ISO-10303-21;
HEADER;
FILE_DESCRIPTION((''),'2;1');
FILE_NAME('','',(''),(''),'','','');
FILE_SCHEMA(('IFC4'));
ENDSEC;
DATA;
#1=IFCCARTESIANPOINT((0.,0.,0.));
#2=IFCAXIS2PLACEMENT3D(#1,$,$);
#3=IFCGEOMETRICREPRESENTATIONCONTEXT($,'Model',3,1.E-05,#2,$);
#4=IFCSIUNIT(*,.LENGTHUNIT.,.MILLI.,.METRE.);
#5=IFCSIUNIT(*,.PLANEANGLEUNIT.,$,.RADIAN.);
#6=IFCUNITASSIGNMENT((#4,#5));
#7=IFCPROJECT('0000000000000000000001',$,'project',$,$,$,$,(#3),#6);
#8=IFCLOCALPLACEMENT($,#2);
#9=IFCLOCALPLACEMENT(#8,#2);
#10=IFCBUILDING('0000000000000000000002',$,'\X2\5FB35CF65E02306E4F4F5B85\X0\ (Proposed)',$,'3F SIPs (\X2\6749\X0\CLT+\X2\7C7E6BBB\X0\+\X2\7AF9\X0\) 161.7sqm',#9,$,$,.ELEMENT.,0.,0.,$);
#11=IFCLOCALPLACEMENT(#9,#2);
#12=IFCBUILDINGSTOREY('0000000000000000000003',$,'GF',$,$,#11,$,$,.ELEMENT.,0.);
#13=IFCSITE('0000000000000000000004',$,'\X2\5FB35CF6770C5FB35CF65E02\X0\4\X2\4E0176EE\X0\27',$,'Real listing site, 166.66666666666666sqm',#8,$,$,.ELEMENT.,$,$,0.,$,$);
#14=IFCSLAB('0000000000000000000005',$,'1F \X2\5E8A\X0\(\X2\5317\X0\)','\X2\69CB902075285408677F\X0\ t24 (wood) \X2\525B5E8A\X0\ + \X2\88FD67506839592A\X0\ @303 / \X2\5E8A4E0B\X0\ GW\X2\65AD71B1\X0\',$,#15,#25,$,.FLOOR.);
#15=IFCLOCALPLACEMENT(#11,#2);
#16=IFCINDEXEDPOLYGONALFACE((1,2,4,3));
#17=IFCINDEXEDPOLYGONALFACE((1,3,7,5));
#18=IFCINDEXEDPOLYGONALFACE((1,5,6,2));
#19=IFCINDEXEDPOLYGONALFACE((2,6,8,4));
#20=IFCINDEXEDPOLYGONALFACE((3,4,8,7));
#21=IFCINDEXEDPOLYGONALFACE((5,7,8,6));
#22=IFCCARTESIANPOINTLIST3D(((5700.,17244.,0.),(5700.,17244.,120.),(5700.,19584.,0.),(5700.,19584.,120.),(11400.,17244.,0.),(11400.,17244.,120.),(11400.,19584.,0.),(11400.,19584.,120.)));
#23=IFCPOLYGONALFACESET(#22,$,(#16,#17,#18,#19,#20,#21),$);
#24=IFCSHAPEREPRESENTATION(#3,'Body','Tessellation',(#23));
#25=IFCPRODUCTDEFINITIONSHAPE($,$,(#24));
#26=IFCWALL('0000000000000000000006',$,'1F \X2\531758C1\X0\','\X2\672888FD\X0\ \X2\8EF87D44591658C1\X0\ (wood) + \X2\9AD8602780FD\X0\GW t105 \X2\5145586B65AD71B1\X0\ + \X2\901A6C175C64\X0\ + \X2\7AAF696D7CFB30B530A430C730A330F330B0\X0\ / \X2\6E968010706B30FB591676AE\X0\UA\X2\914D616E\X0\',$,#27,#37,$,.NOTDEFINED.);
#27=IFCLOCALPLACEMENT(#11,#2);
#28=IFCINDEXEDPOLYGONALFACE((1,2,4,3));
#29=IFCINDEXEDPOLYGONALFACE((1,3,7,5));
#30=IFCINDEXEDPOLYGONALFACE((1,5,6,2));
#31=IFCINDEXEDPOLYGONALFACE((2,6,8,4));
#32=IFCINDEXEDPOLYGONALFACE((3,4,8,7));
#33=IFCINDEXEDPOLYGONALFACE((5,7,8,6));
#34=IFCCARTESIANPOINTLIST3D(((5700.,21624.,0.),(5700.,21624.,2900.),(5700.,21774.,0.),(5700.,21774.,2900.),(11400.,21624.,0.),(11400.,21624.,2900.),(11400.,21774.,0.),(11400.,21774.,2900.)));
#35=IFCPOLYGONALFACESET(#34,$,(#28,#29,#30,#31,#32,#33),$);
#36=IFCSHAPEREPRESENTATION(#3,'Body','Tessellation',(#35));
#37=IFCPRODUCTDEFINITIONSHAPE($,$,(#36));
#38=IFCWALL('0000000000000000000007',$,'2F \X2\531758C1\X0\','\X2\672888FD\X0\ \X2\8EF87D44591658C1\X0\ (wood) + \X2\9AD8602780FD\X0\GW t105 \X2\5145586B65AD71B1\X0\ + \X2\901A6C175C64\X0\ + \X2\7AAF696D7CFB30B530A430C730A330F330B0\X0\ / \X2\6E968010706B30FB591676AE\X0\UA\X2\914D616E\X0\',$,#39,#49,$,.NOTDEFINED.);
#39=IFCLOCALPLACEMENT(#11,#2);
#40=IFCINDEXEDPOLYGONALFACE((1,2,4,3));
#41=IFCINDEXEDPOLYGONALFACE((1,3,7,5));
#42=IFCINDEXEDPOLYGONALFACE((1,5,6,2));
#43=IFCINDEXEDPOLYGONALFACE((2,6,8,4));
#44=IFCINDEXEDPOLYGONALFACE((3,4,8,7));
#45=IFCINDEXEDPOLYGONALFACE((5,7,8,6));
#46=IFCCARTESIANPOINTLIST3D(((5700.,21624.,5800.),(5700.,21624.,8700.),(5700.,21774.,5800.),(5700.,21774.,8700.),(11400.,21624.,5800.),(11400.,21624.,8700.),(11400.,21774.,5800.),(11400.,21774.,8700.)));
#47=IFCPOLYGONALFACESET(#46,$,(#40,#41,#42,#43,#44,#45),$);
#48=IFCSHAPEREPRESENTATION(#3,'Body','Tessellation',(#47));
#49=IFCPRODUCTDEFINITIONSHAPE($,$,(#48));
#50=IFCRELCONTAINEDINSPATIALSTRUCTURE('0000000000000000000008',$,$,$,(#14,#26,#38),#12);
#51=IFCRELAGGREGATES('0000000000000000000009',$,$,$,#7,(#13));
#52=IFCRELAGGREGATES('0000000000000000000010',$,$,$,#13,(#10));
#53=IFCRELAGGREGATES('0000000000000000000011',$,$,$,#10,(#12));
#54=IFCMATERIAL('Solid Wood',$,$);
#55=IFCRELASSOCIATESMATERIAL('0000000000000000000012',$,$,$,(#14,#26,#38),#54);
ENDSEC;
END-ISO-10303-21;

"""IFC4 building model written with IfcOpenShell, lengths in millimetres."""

from ifc_helpers import new_model, si_unit, frame, frame_2d, origin, place, context, project, spatial, rectangle, extrude, material, element, save


model = new_model("IFC4")

# Units and contexts
model_context = context("Model", 3, precision=1e-05, world=origin())
ifc_project = project(units=[si_unit("LENGTHUNIT", "METRE", prefix="MILLI"), si_unit("PLANEANGLEUNIT", "RADIAN")], contexts=[model_context])

# Site, building, storey
site_placement = place(None, origin())
site = spatial("IfcSite", under=ifc_project, at=site_placement, Name="徳島県徳島市4丁目27", ObjectType="Real listing site, 166.66666666666666sqm", CompositionType="ELEMENT", RefElevation=0.0)
building_placement = place(site_placement, origin())
building = spatial("IfcBuilding", under=site, at=building_placement, Name="徳島市の住宅 (Proposed)", ObjectType="3F SIPs (杉CLT+籾殻+竹) 161.7sqm", CompositionType="ELEMENT", ElevationOfRefHeight=0.0, ElevationOfTerrain=0.0)
storey_placement = place(building_placement, origin())
storey = spatial("IfcBuildingStorey", under=building, at=storey_placement, Name="GF", CompositionType="ELEMENT", Elevation=0.0)

# Slab
ifc_material_1 = material(Name="Solid Wood")
slab_1_placement = place(storey_placement, frame((2850.0, 8622.0, 0.0)))
element("IfcSlab", 1, at=slab_1_placement, inside=storey, material=ifc_material_1, Name="1F 床(北)", Description="構造用合板 t24 (wood) 剛床 + 製材根太 @303 / 床下 GW断熱", PredefinedType="FLOOR", context=model_context, shape_type="SweptSolid", body=[
    extrude(rectangle(XDim=5700.0, YDim=2340.0, at=frame_2d((2850.0, 1170.0))), frame((2850.0, 8622.0, 0.0)), (0.0, 0.0, 1.0), 120.0),
])

# Wall
wall_1_placement = place(storey_placement, frame((2850.0, 10812.0, 0.0)))
element("IfcWall", 2, at=wall_1_placement, inside=storey, material=ifc_material_1, Name="1F 北壁", Description="木製 軸組外壁 (wood) + 高性能GW t105 充填断熱 + 通気層 + 窯業系サイディング / 準耐火・外皮UA配慮", PredefinedType="NOTDEFINED", context=model_context, shape_type="SweptSolid", body=[
    extrude(rectangle(XDim=5700.0, YDim=150.0, at=frame_2d((2850.0, 75.0))), frame((2850.0, 10812.0, 0.0)), (0.0, 0.0, 1.0), 2900.0),
])

# Wall
wall_2_placement = place(storey_placement, frame((2850.0, 10812.0, 2900.0)))
element("IfcWall", 3, at=wall_2_placement, inside=storey, material=ifc_material_1, Name="2F 北壁", Description="木製 軸組外壁 (wood) + 高性能GW t105 充填断熱 + 通気層 + 窯業系サイディング / 準耐火・外皮UA配慮", PredefinedType="NOTDEFINED", context=model_context, shape_type="SweptSolid", body=[
    extrude(rectangle(XDim=5700.0, YDim=150.0, at=frame_2d((2850.0, 75.0))), frame((2850.0, 10812.0, 2900.0)), (0.0, 0.0, 1.0), 2900.0),
])

save(model, "model.ifc")
